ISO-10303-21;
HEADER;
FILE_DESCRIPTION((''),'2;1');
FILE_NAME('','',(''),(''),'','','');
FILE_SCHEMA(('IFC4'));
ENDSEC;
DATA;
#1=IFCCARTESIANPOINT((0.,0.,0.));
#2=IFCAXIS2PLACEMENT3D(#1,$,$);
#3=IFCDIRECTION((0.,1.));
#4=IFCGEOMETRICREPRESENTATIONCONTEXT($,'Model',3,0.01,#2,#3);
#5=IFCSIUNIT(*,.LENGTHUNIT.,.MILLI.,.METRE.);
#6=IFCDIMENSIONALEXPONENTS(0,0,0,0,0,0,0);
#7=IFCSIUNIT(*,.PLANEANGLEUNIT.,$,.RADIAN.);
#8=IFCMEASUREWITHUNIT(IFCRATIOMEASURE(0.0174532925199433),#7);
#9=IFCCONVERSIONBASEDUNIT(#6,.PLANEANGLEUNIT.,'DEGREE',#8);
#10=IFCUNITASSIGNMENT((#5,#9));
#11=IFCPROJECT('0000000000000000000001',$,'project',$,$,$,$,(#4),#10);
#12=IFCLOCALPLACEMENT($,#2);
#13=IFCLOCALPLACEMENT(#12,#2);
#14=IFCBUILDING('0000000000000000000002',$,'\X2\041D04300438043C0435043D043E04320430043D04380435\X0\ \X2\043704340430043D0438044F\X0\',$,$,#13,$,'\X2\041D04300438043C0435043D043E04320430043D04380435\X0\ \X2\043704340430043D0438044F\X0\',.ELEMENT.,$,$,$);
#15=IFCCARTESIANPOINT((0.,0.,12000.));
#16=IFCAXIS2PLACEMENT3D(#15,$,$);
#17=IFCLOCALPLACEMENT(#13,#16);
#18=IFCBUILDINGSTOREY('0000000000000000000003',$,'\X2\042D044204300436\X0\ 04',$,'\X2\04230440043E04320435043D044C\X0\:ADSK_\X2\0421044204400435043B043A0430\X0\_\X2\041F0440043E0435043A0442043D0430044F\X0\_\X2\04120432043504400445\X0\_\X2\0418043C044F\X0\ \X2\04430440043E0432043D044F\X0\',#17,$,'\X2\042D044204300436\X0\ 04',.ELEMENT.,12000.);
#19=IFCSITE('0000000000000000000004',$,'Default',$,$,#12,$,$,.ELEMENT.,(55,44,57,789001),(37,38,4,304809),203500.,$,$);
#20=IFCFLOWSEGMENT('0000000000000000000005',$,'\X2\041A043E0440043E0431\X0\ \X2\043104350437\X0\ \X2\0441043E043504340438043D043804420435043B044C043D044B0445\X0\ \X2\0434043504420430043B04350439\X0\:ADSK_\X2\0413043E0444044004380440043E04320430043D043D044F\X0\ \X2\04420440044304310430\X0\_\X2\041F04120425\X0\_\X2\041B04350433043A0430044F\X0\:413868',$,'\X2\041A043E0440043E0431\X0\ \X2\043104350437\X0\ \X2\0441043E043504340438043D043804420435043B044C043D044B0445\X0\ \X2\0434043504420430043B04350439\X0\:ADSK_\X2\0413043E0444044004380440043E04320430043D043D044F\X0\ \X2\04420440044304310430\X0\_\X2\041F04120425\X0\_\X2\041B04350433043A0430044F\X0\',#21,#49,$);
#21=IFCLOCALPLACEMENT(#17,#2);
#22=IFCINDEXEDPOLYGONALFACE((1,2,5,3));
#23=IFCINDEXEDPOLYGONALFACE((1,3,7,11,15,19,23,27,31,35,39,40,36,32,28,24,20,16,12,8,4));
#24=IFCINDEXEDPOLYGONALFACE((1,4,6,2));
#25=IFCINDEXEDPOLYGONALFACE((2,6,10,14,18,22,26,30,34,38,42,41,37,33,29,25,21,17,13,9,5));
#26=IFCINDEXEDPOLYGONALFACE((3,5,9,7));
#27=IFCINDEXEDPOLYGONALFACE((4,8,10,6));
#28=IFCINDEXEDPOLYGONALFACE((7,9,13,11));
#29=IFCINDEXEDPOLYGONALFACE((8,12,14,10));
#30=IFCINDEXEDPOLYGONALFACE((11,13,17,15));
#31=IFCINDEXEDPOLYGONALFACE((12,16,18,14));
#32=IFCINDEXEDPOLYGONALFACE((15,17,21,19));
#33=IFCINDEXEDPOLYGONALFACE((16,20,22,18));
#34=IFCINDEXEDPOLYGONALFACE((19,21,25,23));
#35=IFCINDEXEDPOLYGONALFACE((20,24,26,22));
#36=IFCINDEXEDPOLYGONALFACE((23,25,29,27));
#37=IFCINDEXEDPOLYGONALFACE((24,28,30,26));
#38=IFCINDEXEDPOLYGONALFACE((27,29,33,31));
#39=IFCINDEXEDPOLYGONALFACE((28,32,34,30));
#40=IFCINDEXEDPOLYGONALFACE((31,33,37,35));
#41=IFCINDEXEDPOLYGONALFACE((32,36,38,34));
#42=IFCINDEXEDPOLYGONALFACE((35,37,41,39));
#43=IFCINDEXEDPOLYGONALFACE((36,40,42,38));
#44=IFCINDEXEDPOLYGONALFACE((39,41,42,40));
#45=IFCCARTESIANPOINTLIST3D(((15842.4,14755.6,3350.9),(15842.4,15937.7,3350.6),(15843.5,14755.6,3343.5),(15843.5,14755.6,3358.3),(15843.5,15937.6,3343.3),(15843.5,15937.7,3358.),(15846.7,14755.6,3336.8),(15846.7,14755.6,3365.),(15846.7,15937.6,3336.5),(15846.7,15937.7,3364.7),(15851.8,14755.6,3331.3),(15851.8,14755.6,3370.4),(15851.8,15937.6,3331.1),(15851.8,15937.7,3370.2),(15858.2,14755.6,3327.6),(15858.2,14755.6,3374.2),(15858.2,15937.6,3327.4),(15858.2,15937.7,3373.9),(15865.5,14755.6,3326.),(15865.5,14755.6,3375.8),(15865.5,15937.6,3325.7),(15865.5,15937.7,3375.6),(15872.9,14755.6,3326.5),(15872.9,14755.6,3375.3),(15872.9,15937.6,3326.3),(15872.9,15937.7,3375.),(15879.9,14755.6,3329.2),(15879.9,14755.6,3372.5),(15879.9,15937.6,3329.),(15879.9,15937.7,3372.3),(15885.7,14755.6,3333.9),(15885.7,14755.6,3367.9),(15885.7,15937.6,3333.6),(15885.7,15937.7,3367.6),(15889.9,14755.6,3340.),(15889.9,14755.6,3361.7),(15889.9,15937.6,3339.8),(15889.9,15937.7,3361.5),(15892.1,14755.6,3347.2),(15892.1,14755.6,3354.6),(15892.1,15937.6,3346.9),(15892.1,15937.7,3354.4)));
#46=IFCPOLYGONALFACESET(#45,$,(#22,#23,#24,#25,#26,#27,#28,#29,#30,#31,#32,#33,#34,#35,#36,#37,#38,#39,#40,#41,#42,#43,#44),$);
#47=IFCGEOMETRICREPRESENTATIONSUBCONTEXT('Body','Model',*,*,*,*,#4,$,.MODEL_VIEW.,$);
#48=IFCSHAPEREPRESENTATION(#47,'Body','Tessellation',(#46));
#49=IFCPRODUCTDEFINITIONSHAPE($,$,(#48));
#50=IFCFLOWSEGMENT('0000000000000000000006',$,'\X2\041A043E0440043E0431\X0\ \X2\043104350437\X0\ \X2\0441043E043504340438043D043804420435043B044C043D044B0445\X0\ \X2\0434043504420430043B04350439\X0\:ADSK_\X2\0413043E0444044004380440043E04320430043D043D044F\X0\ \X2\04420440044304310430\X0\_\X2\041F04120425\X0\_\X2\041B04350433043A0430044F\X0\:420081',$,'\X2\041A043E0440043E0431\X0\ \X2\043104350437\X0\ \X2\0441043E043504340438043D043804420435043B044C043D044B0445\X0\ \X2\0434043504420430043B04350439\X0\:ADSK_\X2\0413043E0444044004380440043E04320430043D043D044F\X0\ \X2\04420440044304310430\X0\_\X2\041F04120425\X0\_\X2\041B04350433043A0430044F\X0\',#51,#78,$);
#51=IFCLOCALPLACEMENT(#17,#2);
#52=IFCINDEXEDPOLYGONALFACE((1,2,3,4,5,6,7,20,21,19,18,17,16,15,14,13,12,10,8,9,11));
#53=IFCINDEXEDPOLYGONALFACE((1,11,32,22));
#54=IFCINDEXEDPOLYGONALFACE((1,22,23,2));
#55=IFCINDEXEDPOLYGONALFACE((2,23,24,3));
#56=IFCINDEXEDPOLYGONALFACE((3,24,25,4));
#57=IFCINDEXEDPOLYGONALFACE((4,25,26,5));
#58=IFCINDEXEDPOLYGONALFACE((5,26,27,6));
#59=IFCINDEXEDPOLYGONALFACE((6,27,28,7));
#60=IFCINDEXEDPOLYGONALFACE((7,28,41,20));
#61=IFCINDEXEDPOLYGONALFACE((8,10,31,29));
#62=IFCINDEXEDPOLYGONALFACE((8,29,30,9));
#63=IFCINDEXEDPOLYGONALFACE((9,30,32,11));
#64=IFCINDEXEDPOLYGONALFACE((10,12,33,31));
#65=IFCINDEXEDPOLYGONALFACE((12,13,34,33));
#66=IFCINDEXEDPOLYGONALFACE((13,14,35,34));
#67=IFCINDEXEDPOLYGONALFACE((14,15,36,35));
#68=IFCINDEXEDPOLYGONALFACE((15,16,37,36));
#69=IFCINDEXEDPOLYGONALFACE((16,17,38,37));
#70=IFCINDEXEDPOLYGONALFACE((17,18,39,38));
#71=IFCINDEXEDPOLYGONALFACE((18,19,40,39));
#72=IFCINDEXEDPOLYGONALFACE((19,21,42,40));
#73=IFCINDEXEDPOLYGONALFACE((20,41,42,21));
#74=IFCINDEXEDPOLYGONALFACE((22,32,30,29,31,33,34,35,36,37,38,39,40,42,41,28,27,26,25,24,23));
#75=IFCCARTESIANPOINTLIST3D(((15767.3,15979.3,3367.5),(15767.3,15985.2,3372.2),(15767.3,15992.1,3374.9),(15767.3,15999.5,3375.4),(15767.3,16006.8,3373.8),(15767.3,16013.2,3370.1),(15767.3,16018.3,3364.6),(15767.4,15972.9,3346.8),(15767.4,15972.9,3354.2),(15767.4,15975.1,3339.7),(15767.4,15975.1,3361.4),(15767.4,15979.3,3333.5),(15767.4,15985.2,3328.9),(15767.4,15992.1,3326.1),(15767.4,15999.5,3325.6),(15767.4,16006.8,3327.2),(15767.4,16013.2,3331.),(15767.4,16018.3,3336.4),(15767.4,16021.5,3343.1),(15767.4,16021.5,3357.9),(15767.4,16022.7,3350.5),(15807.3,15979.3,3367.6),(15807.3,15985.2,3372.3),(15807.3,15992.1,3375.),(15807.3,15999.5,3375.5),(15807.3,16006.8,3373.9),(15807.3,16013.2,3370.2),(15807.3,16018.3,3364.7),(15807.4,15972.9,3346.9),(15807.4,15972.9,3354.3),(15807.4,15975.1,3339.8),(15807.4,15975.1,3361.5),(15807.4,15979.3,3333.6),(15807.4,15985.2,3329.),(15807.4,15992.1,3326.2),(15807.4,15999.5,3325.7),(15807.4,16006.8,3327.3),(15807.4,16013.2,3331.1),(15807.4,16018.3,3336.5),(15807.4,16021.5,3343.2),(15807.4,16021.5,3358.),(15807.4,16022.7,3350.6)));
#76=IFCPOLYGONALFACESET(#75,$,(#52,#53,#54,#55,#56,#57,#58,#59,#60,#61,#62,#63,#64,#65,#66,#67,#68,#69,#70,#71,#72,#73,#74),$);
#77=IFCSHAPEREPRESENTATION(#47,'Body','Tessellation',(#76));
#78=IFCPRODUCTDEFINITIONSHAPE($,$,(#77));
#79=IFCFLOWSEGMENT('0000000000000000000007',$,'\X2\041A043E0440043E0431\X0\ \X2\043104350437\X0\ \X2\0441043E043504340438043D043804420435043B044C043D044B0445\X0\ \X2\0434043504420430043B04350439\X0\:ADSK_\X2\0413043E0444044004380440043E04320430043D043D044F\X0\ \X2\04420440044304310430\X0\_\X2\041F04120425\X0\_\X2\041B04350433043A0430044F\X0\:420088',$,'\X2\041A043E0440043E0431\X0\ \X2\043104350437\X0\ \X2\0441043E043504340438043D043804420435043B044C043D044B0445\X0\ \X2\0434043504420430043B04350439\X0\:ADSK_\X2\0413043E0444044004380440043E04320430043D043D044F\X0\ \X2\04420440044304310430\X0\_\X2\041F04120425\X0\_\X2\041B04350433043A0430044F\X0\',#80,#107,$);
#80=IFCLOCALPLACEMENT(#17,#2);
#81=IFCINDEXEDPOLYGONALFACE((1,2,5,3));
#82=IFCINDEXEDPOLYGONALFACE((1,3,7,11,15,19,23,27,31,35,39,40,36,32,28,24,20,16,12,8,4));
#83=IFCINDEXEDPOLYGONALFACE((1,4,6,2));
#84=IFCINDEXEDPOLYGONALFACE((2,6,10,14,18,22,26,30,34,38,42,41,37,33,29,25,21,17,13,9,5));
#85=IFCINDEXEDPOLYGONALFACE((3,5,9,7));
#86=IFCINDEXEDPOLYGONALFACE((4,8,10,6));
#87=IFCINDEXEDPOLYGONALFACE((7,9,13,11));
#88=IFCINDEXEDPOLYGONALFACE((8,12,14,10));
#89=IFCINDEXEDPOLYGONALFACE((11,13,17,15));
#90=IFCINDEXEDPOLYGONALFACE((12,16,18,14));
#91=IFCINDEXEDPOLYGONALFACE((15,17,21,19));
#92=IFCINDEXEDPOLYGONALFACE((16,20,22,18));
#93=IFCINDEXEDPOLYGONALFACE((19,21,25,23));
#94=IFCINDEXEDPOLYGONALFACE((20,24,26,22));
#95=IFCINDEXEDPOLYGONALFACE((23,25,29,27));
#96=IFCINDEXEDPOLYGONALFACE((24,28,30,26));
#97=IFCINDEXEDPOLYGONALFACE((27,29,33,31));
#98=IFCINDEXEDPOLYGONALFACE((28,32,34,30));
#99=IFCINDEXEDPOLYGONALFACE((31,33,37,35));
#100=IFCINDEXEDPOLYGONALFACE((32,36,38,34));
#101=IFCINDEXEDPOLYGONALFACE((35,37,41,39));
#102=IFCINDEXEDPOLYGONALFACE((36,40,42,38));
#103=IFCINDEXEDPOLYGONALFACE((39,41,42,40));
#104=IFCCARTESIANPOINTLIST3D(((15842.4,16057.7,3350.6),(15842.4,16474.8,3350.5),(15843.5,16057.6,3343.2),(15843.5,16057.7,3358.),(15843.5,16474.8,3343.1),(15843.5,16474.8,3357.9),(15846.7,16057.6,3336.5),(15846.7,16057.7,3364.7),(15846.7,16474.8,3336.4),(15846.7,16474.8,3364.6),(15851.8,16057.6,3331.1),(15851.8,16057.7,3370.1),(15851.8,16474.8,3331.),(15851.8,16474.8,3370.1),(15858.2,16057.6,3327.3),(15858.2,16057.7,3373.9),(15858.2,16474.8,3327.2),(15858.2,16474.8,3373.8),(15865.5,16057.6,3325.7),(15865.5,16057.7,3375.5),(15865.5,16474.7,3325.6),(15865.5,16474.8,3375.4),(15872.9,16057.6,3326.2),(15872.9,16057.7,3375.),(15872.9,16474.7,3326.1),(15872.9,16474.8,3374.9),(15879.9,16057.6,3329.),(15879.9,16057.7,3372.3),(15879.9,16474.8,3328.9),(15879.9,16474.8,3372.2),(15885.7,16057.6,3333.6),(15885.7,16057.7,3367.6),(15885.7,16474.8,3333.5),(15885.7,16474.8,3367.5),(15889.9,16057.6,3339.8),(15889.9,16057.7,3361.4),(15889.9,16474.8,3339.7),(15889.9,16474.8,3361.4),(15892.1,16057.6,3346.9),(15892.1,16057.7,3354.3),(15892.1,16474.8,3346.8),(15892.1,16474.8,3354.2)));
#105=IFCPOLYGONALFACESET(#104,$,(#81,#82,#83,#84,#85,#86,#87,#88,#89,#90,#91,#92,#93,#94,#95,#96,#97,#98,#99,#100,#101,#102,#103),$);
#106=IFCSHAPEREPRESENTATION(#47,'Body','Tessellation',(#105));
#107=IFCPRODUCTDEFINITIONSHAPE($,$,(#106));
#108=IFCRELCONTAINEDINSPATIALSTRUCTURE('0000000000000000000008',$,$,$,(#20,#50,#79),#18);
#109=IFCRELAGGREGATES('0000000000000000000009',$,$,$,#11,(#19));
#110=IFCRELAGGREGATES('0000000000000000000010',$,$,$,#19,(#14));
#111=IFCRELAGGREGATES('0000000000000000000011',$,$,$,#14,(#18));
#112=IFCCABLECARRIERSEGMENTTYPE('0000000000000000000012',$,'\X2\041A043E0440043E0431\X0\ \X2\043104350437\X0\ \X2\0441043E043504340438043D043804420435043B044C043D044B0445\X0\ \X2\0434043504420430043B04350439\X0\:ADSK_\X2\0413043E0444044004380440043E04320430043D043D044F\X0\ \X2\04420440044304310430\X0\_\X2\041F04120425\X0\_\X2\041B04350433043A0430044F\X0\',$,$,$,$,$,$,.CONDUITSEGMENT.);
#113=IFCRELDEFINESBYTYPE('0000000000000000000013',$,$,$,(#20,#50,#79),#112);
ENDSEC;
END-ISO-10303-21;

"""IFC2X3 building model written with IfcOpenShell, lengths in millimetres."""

from ifc_helpers import new_model, entity, si_unit, converted_unit, direction, frame, frame_2d, origin, origin_2d_with_axis, place, context, subcontext, project, spatial, circle, extrude, type_object, element, save


model = new_model("IFC2X3")

# Units and contexts
model_context = context("Model", 3, precision=0.01, world=origin(), true_north=direction((0.0, 1.0)))
body_context = subcontext(model_context, "Body", "Model", "MODEL_VIEW")
ifc_project = project(units=[si_unit("LENGTHUNIT", "METRE", prefix="MILLI"), converted_unit("PLANEANGLEUNIT", "DEGREE", entity("IfcRatioMeasure", 0.0174532925199433), si_unit("PLANEANGLEUNIT", "RADIAN"), dimensions=[0, 0, 0, 0, 0, 0, 0])], contexts=[model_context])

# Site, building, storey
site_placement = place(None, frame((0.0, 0.0, 0.0)))
site = spatial("IfcSite", under=ifc_project, at=site_placement, Name="Default", CompositionType="ELEMENT", RefLatitude=(55, 44, 57, 789001), RefLongitude=(37, 38, 4, 304809), RefElevation=203500.0)
building_placement = place(site_placement, origin())
building = spatial("IfcBuilding", under=site, at=building_placement, Name="Наименование здания", LongName="Наименование здания", CompositionType="ELEMENT")
storey_placement = place(building_placement, frame((0.0, 0.0, 12000.0)))
storey = spatial("IfcBuildingStorey", under=building, at=storey_placement, Name="Этаж 04", ObjectType="Уровень:ADSK_Стрелка_Проектная_Вверх_Имя уровня", LongName="Этаж 04", CompositionType="ELEMENT", Elevation=12000.0)

# Flow segments
cable_carrier_segment_type = type_object("IfcCableCarrierSegmentType", Name="Короб без соединительных деталей:ADSK_Гофрировання труба_ПВХ_Легкая", PredefinedType="CONDUITSEGMENT")
flow_segment_1_placement = place(storey_placement, frame((15840.8, 14755.6, 3324.0)))
element("IfcFlowSegment", 1, at=flow_segment_1_placement, inside=storey, type_object=cable_carrier_segment_type, Name="Короб без соединительных деталей:ADSK_Гофрировання труба_ПВХ_Легкая:413868", ObjectType="Короб без соединительных деталей:ADSK_Гофрировання труба_ПВХ_Легкая", context=body_context, shape_type="SweptSolid", body=[
    extrude(circle(Radius=25.0, at=origin_2d_with_axis()), frame((26.6, 1182.0, 26.6), z_axis=(0.0, -1.0, 0.000223), x_axis=(-1.0, 0.0, 0.0)), (0.0, 0.0, 1.0), 1182.0),
])
flow_segment_2_placement = place(storey_placement, frame((15767.3, 15971.1, 3323.9)))
element("IfcFlowSegment", 2, at=flow_segment_2_placement, inside=storey, type_object=cable_carrier_segment_type, Name="Короб без соединительных деталей:ADSK_Гофрировання труба_ПВХ_Легкая:420081", ObjectType="Короб без соединительных деталей:ADSK_Гофрировання труба_ПВХ_Легкая", context=body_context, shape_type="SweptSolid", body=[
    extrude(circle(Radius=25.0, at=frame_2d((0.0, 0.0), x_axis=(1.0, 0.0))), frame((0.1, 26.6, 26.6), z_axis=(0.999996, 0.0, 0.002665), x_axis=(0.0, 1.0, 0.0)), (0.0, 0.0, 1.0), 40.0),
])
flow_segment_3_placement = place(storey_placement, frame((15840.8, 16057.6, 3323.9)))
element("IfcFlowSegment", 3, at=flow_segment_3_placement, inside=storey, type_object=cable_carrier_segment_type, Name="Короб без соединительных деталей:ADSK_Гофрировання труба_ПВХ_Легкая:420088", ObjectType="Короб без соединительных деталей:ADSK_Гофрировання труба_ПВХ_Легкая", context=body_context, shape_type="SweptSolid", body=[
    extrude(circle(Radius=25.0, at=origin_2d_with_axis()), frame((26.6, 417.1, 26.6), z_axis=(0.0, -1.0, 0.000223), x_axis=(-1.0, 0.0, 0.0)), (0.0, 0.0, 1.0), 417.1),
])

save(model, "model.ifc")
